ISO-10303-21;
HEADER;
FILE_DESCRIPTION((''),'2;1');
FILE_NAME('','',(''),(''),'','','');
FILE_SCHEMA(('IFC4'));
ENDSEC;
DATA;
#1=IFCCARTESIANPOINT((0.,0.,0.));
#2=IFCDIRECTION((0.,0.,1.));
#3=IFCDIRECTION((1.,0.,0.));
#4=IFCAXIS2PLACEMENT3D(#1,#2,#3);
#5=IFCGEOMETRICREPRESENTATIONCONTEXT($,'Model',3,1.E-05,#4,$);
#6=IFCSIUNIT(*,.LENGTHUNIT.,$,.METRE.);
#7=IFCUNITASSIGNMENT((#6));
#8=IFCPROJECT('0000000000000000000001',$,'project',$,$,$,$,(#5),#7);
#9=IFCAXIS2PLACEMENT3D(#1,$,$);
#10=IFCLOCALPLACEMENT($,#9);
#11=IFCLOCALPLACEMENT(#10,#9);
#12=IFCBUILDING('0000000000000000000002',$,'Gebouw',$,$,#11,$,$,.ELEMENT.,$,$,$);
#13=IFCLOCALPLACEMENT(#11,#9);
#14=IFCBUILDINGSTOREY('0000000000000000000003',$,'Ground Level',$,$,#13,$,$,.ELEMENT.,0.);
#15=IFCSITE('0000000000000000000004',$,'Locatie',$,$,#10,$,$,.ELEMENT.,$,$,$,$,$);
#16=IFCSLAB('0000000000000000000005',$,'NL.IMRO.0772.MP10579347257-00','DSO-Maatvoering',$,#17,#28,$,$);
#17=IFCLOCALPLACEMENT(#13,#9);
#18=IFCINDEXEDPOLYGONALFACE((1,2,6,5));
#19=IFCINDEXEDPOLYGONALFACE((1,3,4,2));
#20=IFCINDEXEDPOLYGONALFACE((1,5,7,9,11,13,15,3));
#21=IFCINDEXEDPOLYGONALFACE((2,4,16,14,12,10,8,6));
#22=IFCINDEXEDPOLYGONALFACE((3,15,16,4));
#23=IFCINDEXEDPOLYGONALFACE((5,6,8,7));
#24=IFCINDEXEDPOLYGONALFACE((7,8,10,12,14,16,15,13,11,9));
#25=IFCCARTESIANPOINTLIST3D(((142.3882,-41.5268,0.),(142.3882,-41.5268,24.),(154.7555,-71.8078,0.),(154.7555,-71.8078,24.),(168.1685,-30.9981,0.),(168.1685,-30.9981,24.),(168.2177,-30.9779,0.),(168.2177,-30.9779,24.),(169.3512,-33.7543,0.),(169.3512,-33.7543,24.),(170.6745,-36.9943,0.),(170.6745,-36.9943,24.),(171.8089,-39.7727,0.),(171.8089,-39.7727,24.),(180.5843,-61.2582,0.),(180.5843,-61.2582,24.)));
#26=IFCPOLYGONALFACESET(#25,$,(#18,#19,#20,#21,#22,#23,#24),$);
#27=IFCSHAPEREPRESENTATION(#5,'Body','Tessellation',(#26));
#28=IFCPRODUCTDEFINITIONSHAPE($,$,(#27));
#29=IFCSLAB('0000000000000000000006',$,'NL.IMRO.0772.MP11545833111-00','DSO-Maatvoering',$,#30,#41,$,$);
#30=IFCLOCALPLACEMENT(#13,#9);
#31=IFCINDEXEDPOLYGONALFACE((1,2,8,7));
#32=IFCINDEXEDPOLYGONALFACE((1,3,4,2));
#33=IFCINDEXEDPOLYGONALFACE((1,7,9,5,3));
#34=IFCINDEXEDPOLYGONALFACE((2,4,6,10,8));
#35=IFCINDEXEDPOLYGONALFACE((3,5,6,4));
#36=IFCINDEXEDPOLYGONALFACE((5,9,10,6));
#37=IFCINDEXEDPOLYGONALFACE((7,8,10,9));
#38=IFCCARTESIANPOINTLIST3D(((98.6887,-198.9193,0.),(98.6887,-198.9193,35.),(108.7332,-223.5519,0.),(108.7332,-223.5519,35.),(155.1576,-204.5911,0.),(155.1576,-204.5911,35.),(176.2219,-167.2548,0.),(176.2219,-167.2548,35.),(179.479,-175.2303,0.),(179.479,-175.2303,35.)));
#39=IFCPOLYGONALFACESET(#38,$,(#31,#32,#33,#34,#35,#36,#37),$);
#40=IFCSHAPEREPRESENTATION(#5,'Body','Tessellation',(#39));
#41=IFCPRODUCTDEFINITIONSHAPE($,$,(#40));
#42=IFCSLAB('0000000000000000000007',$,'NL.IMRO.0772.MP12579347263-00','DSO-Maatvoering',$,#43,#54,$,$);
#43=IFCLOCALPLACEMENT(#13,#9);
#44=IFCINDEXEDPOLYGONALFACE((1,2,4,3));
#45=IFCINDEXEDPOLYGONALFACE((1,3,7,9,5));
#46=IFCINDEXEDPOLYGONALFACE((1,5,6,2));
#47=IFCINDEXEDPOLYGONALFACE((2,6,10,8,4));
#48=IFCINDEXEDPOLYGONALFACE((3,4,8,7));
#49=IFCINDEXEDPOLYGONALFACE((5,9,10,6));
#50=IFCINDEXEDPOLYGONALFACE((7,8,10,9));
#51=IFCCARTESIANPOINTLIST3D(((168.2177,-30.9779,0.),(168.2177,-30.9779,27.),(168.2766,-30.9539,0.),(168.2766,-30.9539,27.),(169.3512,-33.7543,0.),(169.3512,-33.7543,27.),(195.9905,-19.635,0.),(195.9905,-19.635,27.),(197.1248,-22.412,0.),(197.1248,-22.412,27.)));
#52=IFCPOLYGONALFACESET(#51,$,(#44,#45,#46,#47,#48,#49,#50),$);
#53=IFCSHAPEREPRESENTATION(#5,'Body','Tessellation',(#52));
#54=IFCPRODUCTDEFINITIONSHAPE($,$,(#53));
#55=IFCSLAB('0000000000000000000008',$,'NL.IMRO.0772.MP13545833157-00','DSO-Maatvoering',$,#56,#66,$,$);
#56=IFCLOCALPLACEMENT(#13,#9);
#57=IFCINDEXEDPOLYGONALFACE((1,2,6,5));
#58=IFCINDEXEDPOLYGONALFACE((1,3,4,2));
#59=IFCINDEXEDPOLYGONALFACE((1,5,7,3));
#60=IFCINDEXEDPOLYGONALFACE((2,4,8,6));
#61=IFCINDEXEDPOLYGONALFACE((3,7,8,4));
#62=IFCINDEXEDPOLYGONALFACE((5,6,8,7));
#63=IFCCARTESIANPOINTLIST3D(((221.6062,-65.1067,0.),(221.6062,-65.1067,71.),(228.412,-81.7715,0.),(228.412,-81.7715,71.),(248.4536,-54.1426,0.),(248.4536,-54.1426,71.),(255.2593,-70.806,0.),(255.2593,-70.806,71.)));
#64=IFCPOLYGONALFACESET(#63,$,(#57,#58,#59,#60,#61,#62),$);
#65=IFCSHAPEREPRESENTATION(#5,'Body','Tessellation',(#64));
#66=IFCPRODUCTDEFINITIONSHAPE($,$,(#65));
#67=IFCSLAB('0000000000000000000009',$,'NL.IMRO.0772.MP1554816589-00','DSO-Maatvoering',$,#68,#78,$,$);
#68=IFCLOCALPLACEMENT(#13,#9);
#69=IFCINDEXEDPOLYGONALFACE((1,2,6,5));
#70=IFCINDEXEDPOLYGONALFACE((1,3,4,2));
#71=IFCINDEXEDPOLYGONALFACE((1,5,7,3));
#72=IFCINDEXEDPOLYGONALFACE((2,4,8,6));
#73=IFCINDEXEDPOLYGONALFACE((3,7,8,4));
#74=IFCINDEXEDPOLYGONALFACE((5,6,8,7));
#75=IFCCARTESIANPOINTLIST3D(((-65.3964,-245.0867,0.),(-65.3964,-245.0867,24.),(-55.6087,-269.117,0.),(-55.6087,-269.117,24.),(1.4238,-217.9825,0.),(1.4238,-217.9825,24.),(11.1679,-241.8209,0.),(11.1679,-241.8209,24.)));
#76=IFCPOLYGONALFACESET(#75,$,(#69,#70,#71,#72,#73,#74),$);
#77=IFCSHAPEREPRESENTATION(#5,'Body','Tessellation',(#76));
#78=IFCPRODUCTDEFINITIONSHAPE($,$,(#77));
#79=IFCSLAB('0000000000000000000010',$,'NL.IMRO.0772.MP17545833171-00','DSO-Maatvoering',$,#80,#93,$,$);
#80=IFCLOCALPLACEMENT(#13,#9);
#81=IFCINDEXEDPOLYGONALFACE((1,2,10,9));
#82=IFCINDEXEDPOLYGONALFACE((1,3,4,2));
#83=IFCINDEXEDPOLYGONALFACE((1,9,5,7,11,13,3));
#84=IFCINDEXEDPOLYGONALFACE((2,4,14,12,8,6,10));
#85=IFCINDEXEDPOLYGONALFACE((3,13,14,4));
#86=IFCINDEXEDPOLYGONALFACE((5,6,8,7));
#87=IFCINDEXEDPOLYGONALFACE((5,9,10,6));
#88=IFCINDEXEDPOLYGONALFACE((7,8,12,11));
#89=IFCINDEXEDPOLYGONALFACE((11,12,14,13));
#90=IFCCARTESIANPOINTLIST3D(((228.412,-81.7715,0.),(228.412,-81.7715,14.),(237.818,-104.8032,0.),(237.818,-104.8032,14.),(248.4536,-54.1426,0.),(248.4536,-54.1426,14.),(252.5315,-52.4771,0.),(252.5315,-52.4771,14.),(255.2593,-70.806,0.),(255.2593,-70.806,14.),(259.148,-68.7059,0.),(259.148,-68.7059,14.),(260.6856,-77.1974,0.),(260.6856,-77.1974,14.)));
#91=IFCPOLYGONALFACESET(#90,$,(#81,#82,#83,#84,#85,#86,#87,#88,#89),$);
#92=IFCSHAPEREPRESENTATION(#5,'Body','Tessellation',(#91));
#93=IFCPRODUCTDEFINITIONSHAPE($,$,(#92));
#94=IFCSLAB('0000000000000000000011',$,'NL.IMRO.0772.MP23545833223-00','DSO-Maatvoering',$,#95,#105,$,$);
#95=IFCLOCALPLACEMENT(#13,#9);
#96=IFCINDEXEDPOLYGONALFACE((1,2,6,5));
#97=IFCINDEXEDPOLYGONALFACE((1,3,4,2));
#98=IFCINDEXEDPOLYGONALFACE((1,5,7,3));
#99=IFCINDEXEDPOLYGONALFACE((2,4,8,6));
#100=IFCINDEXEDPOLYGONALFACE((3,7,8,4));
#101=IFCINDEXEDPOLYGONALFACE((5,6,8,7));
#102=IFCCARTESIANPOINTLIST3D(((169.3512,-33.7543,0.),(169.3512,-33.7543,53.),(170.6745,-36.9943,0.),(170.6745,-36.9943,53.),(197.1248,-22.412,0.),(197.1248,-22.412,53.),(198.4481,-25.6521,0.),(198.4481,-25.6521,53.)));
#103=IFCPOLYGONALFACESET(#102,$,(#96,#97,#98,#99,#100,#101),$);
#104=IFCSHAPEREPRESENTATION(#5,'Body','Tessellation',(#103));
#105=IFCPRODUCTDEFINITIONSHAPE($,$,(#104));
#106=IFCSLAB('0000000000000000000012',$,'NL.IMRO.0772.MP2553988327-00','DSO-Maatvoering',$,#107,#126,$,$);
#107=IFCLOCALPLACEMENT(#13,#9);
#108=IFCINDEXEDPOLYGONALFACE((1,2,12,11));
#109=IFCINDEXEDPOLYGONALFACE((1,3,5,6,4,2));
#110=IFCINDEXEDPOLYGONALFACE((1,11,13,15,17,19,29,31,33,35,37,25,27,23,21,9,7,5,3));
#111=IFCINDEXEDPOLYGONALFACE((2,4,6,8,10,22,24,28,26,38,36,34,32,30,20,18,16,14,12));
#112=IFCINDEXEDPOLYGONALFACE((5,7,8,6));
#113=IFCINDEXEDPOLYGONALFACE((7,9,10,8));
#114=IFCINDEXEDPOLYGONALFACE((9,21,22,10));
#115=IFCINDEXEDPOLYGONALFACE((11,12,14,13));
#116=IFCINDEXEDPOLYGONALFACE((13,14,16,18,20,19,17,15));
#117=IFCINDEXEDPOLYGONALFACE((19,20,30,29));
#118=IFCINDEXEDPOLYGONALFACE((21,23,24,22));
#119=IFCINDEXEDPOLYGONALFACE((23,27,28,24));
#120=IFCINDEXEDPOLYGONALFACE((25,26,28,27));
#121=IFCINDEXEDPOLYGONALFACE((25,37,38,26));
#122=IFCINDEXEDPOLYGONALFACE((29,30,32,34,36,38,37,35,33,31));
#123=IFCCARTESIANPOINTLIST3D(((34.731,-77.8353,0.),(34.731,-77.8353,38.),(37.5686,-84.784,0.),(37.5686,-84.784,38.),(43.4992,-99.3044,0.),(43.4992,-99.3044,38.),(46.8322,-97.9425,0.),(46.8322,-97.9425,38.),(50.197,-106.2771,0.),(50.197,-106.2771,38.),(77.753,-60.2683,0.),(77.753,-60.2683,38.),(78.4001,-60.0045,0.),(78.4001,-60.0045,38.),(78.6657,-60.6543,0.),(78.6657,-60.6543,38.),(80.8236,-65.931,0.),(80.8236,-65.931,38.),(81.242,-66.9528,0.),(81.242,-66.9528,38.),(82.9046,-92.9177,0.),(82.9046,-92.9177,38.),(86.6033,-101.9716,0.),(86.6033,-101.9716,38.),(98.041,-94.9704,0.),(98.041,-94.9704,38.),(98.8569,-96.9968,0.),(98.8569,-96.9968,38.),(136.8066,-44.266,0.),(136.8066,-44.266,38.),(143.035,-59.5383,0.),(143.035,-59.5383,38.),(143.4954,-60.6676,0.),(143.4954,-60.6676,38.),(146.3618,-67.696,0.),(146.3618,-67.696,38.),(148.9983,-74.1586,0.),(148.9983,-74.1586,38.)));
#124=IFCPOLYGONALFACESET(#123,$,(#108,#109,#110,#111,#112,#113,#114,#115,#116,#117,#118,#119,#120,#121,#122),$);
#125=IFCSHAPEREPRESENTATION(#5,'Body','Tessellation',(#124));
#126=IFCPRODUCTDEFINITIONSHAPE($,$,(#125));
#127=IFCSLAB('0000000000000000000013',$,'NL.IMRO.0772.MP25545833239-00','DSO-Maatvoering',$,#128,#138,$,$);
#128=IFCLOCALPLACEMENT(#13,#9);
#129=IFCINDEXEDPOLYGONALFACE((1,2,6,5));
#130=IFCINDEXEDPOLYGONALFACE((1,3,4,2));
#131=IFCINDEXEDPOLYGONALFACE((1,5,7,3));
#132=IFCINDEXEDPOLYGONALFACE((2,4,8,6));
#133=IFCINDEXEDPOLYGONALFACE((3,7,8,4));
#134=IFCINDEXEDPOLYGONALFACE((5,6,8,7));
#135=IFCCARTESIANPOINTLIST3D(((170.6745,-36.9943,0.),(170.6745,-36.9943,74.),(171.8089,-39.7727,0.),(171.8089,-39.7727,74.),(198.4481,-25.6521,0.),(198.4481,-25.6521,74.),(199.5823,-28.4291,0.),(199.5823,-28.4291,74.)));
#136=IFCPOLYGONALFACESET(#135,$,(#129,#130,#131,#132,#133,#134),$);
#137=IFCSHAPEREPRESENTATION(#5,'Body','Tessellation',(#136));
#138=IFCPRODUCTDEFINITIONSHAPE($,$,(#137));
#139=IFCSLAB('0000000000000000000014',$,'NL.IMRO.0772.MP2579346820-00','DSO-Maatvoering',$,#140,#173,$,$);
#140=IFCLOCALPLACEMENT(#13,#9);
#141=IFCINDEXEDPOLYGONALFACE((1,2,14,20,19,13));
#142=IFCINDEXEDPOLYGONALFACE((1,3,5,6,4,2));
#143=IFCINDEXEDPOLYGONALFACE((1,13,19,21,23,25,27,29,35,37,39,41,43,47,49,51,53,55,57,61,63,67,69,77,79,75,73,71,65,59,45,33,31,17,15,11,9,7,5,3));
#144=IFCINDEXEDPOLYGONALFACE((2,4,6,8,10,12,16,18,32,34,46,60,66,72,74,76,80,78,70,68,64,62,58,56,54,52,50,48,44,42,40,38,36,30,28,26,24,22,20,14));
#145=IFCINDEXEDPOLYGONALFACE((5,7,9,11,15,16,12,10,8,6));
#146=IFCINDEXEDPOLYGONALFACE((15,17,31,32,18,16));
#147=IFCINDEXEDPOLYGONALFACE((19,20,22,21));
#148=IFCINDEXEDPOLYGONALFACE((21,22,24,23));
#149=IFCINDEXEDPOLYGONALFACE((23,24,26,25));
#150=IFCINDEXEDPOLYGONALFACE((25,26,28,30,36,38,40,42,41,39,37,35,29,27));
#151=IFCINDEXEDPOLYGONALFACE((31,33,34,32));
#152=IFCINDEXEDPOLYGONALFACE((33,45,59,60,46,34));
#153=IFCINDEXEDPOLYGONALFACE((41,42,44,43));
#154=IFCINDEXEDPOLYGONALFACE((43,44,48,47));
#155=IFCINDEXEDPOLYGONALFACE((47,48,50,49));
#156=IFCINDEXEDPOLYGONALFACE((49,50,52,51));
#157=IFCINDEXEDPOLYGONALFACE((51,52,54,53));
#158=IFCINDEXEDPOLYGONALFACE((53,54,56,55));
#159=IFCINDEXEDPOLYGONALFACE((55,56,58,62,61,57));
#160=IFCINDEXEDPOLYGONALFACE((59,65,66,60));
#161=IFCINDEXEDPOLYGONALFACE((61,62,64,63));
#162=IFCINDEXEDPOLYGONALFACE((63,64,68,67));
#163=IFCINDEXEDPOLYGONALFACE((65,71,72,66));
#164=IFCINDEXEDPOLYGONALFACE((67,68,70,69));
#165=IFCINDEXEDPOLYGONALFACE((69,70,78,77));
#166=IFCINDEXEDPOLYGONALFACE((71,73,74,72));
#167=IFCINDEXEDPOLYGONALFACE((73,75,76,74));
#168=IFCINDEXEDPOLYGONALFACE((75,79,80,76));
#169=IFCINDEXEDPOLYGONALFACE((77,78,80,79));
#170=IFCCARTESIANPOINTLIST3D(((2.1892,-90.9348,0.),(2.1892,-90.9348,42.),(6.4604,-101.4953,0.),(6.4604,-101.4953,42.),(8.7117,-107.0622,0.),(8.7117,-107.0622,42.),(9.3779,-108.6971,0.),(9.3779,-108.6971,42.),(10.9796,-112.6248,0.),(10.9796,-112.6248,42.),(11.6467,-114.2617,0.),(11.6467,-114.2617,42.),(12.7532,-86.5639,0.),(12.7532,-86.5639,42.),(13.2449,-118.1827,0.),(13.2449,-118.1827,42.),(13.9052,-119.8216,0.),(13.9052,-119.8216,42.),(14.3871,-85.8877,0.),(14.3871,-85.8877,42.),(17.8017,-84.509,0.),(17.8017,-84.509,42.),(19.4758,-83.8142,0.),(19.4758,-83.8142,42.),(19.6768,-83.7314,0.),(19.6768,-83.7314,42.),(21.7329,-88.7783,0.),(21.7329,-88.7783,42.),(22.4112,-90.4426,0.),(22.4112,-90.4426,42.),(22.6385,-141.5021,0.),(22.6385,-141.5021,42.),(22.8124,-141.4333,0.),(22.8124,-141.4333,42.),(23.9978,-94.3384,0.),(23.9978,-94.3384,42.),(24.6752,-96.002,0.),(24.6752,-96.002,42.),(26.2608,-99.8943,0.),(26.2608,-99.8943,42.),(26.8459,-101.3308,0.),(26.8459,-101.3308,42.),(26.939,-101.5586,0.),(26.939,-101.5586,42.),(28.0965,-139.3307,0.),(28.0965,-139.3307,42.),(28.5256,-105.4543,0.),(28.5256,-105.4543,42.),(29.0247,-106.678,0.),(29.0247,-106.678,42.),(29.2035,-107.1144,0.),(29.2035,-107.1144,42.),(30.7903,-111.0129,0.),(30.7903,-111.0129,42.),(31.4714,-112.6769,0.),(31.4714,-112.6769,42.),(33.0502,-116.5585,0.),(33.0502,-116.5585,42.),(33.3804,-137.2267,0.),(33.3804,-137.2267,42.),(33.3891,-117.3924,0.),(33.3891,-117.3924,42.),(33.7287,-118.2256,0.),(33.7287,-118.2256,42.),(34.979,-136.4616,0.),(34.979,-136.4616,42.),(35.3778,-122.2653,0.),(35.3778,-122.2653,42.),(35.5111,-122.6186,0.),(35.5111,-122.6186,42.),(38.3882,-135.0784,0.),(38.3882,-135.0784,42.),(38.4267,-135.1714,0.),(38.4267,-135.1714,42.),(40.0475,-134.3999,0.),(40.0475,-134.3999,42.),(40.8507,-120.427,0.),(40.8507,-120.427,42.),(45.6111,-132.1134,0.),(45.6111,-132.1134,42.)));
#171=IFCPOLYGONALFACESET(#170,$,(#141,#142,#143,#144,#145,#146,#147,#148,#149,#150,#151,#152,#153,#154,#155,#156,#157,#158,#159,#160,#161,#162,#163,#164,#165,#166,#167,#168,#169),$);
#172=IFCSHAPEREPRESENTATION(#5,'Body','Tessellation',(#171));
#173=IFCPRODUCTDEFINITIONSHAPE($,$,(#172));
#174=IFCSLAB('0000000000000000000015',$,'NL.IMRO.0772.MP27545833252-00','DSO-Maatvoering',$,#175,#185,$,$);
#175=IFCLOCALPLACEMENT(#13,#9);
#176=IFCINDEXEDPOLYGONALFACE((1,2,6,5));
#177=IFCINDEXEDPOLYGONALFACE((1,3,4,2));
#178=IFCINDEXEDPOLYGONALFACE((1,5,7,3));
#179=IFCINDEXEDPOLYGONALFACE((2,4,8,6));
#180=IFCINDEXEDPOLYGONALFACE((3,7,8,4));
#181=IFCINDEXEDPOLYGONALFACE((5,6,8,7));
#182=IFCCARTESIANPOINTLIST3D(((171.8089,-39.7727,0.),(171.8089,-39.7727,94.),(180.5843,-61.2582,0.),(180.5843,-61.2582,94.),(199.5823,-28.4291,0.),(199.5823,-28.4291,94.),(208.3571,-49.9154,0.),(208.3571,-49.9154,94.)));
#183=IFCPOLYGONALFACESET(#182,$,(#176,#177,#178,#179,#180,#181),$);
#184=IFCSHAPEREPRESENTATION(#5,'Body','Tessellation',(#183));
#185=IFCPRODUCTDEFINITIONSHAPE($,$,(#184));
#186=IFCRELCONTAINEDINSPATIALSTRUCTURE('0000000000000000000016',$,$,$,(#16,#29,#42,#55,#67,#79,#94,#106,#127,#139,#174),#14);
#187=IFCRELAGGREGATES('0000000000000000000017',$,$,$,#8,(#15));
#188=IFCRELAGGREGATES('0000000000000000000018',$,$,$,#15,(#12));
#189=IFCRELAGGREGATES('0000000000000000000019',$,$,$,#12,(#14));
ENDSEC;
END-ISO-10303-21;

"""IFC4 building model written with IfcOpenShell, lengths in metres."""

from ifc_helpers import new_model, si_unit, origin, origin_with_axes, place, context, project, spatial, polyline, outline, extrude, element, save


model = new_model("IFC4")

# Units and contexts
model_context = context("Model", 3, precision=1e-05, world=origin_with_axes())
ifc_project = project(units=[si_unit("LENGTHUNIT", "METRE")], contexts=[model_context])

# Site, building, storey
site_placement = place(None, origin())
site = spatial("IfcSite", under=ifc_project, at=site_placement, Name="Locatie", CompositionType="ELEMENT")
building_placement = place(site_placement, origin())
building = spatial("IfcBuilding", under=site, at=building_placement, Name="Gebouw", CompositionType="ELEMENT")
storey_placement = place(building_placement, origin())
storey = spatial("IfcBuildingStorey", under=building, at=storey_placement, Name="Ground Level", CompositionType="ELEMENT", Elevation=0.0)

# Slabs
slab_1_placement = place(storey_placement, origin())
element("IfcSlab", 1, at=slab_1_placement, inside=storey, Name="NL.IMRO.0772.MP10579347257-00", Description="DSO-Maatvoering", context=model_context, shape_type="SweptSolid", body=[
    extrude(outline(polyline([(168.1685, -30.9981), (168.2177, -30.9779), (169.3512, -33.7543), (170.6745, -36.9943), (171.8089, -39.7727), (180.5843, -61.2582), (154.7555, -71.8078), (142.3882, -41.5268), (168.1685, -30.9981)])), origin_with_axes(), (0.0, 0.0, 1.0), 24.0),
])
slab_2_placement = place(storey_placement, origin())
element("IfcSlab", 2, at=slab_2_placement, inside=storey, Name="NL.IMRO.0772.MP11545833111-00", Description="DSO-Maatvoering", context=model_context, shape_type="SweptSolid", body=[
    extrude(outline(polyline([(108.7332, -223.5519), (98.6887, -198.9193), (176.2219, -167.2548), (179.479, -175.2303), (155.1576, -204.5911), (108.7332, -223.5519)])), origin_with_axes(), (0.0, 0.0, 1.0), 35.0),
])
slab_3_placement = place(storey_placement, origin())
element("IfcSlab", 3, at=slab_3_placement, inside=storey, Name="NL.IMRO.0772.MP12579347263-00", Description="DSO-Maatvoering", context=model_context, shape_type="SweptSolid", body=[
    extrude(outline(polyline([(168.2177, -30.9779), (168.2766, -30.9539), (195.9905, -19.635), (197.1248, -22.412), (169.3512, -33.7543), (168.2177, -30.9779)])), origin_with_axes(), (0.0, 0.0, 1.0), 27.0),
])
slab_4_placement = place(storey_placement, origin())
element("IfcSlab", 4, at=slab_4_placement, inside=storey, Name="NL.IMRO.0772.MP13545833157-00", Description="DSO-Maatvoering", context=model_context, shape_type="SweptSolid", body=[
    extrude(outline(polyline([(248.4536, -54.1426), (255.2593, -70.806), (228.412, -81.7715), (221.6062, -65.1067), (248.4536, -54.1426)])), origin_with_axes(), (0.0, 0.0, 1.0), 71.0),
])
slab_5_placement = place(storey_placement, origin())
element("IfcSlab", 5, at=slab_5_placement, inside=storey, Name="NL.IMRO.0772.MP1554816589-00", Description="DSO-Maatvoering", context=model_context, shape_type="SweptSolid", body=[
    extrude(outline(polyline([(1.4238, -217.9825), (11.1679, -241.8209), (-55.6087, -269.117), (-65.3964, -245.0867), (1.4238, -217.9825)])), origin_with_axes(), (0.0, 0.0, 1.0), 24.0),
])
slab_6_placement = place(storey_placement, origin())
element("IfcSlab", 6, at=slab_6_placement, inside=storey, Name="NL.IMRO.0772.MP17545833171-00", Description="DSO-Maatvoering", context=model_context, shape_type="SweptSolid", body=[
    extrude(outline(polyline([(228.412, -81.7715), (255.2593, -70.806), (248.4536, -54.1426), (252.5315, -52.4771), (259.148, -68.7059), (260.6856, -77.1974), (237.818, -104.8032), (228.412, -81.7715)])), origin_with_axes(), (0.0, 0.0, 1.0), 14.0),
])
slab_7_placement = place(storey_placement, origin())
element("IfcSlab", 7, at=slab_7_placement, inside=storey, Name="NL.IMRO.0772.MP23545833223-00", Description="DSO-Maatvoering", context=model_context, shape_type="SweptSolid", body=[
    extrude(outline(polyline([(169.3512, -33.7543), (197.1248, -22.412), (198.4481, -25.6521), (170.6745, -36.9943), (169.3512, -33.7543)])), origin_with_axes(), (0.0, 0.0, 1.0), 53.0),
])
slab_8_placement = place(storey_placement, origin())
element("IfcSlab", 8, at=slab_8_placement, inside=storey, Name="NL.IMRO.0772.MP2553988327-00", Description="DSO-Maatvoering", context=model_context, shape_type="SweptSolid", body=[
    extrude(outline(polyline([(78.6657, -60.6543), (80.8236, -65.931), (81.242, -66.9528), (136.8066, -44.266), (143.035, -59.5383), (143.4954, -60.6676), (146.3618, -67.696), (148.9983, -74.1586), (98.041, -94.9704), (98.8569, -96.9968), (86.6033, -101.9716), (82.9046, -92.9177), (50.197, -106.2771), (46.8322, -97.9425), (43.4992, -99.3044), (37.5686, -84.784), (34.731, -77.8353), (77.753, -60.2683), (78.4001, -60.0045), (78.6657, -60.6543)])), origin_with_axes(), (0.0, 0.0, 1.0), 38.0),
])
slab_9_placement = place(storey_placement, origin())
element("IfcSlab", 9, at=slab_9_placement, inside=storey, Name="NL.IMRO.0772.MP25545833239-00", Description="DSO-Maatvoering", context=model_context, shape_type="SweptSolid", body=[
    extrude(outline(polyline([(199.5823, -28.4291), (171.8089, -39.7727), (170.6745, -36.9943), (198.4481, -25.6521), (199.5823, -28.4291)])), origin_with_axes(), (0.0, 0.0, 1.0), 74.0),
])
slab_10_placement = place(storey_placement, origin())
element("IfcSlab", 10, at=slab_10_placement, inside=storey, Name="NL.IMRO.0772.MP2579346820-00", Description="DSO-Maatvoering", context=model_context, shape_type="SweptSolid", body=[
    extrude(outline(polyline([(10.9796, -112.6248), (9.3779, -108.6971), (8.7117, -107.0622), (6.4604, -101.4953), (2.1892, -90.9348), (12.7532, -86.5639), (14.3871, -85.8877), (17.8017, -84.509), (19.4758, -83.8142), (19.6768, -83.7314), (21.7329, -88.7783), (22.4112, -90.4426), (23.9978, -94.3384), (24.6752, -96.002), (26.2608, -99.8943), (26.8459, -101.3308), (26.939, -101.5586), (28.5256, -105.4543), (29.0247, -106.678), (29.2035, -107.1144), (30.7903, -111.0129), (31.4714, -112.6769), (33.0502, -116.5585), (33.3891, -117.3924), (33.7287, -118.2256), (35.3778, -122.2653), (35.5111, -122.6186), (40.8507, -120.427), (45.6111, -132.1134), (40.0475, -134.3999), (38.4267, -135.1714), (38.3882, -135.0784), (34.979, -136.4616), (33.3804, -137.2267), (28.0965, -139.3307), (22.8124, -141.4333), (22.6385, -141.5021), (13.9052, -119.8216), (13.2449, -118.1827), (11.6467, -114.2617), (10.9796, -112.6248)])), origin_with_axes(), (0.0, 0.0, 1.0), 42.0),
])
slab_11_placement = place(storey_placement, origin())
element("IfcSlab", 11, at=slab_11_placement, inside=storey, Name="NL.IMRO.0772.MP27545833252-00", Description="DSO-Maatvoering", context=model_context, shape_type="SweptSolid", body=[
    extrude(outline(polyline([(199.5823, -28.4291), (208.3571, -49.9154), (180.5843, -61.2582), (171.8089, -39.7727), (199.5823, -28.4291)])), origin_with_axes(), (0.0, 0.0, 1.0), 94.0),
])

save(model, "model.ifc")
